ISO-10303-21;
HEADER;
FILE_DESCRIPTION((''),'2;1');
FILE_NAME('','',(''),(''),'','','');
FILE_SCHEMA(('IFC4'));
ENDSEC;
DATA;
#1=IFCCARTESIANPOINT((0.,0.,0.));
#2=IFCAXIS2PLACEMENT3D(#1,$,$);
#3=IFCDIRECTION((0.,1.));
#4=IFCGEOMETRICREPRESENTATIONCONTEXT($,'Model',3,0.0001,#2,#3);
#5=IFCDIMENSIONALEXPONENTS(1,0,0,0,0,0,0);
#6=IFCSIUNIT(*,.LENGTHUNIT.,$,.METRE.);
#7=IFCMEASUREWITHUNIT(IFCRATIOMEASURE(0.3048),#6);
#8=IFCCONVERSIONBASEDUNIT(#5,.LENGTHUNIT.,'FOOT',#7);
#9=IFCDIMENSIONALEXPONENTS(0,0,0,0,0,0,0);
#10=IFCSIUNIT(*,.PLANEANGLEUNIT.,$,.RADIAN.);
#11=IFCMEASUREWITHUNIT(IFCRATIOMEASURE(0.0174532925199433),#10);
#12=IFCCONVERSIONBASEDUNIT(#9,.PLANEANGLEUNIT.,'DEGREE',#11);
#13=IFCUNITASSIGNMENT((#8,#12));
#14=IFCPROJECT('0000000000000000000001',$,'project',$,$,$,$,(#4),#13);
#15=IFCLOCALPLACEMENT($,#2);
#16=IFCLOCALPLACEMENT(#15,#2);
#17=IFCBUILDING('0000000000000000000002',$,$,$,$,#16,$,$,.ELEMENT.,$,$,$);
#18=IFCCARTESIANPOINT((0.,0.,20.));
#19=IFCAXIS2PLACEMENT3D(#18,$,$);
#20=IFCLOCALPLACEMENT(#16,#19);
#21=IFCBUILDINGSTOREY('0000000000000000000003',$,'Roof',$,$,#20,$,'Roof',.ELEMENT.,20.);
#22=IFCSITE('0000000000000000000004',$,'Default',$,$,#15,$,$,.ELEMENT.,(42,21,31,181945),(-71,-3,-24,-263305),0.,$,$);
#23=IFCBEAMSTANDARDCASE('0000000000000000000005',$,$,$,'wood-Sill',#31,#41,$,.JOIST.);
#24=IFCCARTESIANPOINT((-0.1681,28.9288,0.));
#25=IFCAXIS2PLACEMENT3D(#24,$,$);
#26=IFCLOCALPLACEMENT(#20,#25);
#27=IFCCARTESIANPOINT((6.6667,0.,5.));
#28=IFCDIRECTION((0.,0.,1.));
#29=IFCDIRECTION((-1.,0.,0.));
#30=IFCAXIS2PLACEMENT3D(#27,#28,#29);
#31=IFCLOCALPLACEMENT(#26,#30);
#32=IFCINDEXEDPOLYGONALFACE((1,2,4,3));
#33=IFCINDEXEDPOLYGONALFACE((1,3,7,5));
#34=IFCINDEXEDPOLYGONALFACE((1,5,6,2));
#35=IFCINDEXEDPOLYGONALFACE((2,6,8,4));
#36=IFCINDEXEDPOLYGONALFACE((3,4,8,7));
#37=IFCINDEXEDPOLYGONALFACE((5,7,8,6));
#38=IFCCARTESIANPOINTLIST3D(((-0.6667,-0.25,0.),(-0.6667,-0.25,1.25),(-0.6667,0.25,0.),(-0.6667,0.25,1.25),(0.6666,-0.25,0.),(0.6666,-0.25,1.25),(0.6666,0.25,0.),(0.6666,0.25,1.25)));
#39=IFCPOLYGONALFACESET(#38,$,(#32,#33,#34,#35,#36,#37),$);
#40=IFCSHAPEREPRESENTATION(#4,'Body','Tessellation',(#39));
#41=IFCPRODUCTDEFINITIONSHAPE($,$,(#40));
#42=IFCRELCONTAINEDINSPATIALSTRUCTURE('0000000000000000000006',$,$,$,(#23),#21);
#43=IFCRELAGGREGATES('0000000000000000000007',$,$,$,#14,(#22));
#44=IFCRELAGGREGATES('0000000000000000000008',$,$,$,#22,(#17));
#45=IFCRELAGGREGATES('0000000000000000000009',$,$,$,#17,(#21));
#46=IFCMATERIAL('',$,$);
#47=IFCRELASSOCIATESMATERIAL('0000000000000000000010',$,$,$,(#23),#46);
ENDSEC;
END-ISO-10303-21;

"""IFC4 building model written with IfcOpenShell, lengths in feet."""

from ifc_helpers import new_model, entity, si_unit, converted_unit, direction, frame, origin, place, context, project, spatial, rectangle, extrude, material, element, save


model = new_model("IFC4")

# Units and contexts
model_context = context("Model", 3, precision=0.0001, world=origin(), true_north=direction((0.0, 1.0)))
ifc_project = project(units=[converted_unit("LENGTHUNIT", "FOOT", entity("IfcRatioMeasure", 0.3048), si_unit("LENGTHUNIT", "METRE"), dimensions=[1, 0, 0, 0, 0, 0, 0]), converted_unit("PLANEANGLEUNIT", "DEGREE", entity("IfcRatioMeasure", 0.0174532925199433), si_unit("PLANEANGLEUNIT", "RADIAN"), dimensions=[0, 0, 0, 0, 0, 0, 0])], contexts=[model_context])

# Site, building, storey
site_placement = place(None, origin())
site = spatial("IfcSite", under=ifc_project, at=site_placement, Name="Default", CompositionType="ELEMENT", RefLatitude=(42, 21, 31, 181945), RefLongitude=(-71, -3, -24, -263305), RefElevation=0.0)
building_placement = place(site_placement, origin())
building = spatial("IfcBuilding", under=site, at=building_placement, CompositionType="ELEMENT")
storey_placement = place(building_placement, frame((0.0, 0.0, 20.0)))
storey = spatial("IfcBuildingStorey", under=building, at=storey_placement, Name="Roof", LongName="Roof", CompositionType="ELEMENT", Elevation=20.0)

# Shared definitions
placement_1 = place(storey_placement, frame((-0.1681, 28.9288, 0.0)))

# Beam
ifc_material_1 = material(Name="")
for number, where, z_axis, x_axis in (
    (1, (6.6667, 0.0, 5.0), (0.0, 0.0, 1.0), (-1.0, 0.0, 0.0)),
):
    element("IfcBeamStandardCase", number, at=place(placement_1, frame(where, z_axis=z_axis, x_axis=x_axis)), inside=storey, material=ifc_material_1, ObjectType="wood-Sill", PredefinedType="JOIST", context=model_context, shape_type="SweptSolid", body=[
        extrude(rectangle(XDim=1.3333, YDim=0.5), origin(), (0.0, 0.0, 1.0), 1.25),
    ])

save(model, "model.ifc")
